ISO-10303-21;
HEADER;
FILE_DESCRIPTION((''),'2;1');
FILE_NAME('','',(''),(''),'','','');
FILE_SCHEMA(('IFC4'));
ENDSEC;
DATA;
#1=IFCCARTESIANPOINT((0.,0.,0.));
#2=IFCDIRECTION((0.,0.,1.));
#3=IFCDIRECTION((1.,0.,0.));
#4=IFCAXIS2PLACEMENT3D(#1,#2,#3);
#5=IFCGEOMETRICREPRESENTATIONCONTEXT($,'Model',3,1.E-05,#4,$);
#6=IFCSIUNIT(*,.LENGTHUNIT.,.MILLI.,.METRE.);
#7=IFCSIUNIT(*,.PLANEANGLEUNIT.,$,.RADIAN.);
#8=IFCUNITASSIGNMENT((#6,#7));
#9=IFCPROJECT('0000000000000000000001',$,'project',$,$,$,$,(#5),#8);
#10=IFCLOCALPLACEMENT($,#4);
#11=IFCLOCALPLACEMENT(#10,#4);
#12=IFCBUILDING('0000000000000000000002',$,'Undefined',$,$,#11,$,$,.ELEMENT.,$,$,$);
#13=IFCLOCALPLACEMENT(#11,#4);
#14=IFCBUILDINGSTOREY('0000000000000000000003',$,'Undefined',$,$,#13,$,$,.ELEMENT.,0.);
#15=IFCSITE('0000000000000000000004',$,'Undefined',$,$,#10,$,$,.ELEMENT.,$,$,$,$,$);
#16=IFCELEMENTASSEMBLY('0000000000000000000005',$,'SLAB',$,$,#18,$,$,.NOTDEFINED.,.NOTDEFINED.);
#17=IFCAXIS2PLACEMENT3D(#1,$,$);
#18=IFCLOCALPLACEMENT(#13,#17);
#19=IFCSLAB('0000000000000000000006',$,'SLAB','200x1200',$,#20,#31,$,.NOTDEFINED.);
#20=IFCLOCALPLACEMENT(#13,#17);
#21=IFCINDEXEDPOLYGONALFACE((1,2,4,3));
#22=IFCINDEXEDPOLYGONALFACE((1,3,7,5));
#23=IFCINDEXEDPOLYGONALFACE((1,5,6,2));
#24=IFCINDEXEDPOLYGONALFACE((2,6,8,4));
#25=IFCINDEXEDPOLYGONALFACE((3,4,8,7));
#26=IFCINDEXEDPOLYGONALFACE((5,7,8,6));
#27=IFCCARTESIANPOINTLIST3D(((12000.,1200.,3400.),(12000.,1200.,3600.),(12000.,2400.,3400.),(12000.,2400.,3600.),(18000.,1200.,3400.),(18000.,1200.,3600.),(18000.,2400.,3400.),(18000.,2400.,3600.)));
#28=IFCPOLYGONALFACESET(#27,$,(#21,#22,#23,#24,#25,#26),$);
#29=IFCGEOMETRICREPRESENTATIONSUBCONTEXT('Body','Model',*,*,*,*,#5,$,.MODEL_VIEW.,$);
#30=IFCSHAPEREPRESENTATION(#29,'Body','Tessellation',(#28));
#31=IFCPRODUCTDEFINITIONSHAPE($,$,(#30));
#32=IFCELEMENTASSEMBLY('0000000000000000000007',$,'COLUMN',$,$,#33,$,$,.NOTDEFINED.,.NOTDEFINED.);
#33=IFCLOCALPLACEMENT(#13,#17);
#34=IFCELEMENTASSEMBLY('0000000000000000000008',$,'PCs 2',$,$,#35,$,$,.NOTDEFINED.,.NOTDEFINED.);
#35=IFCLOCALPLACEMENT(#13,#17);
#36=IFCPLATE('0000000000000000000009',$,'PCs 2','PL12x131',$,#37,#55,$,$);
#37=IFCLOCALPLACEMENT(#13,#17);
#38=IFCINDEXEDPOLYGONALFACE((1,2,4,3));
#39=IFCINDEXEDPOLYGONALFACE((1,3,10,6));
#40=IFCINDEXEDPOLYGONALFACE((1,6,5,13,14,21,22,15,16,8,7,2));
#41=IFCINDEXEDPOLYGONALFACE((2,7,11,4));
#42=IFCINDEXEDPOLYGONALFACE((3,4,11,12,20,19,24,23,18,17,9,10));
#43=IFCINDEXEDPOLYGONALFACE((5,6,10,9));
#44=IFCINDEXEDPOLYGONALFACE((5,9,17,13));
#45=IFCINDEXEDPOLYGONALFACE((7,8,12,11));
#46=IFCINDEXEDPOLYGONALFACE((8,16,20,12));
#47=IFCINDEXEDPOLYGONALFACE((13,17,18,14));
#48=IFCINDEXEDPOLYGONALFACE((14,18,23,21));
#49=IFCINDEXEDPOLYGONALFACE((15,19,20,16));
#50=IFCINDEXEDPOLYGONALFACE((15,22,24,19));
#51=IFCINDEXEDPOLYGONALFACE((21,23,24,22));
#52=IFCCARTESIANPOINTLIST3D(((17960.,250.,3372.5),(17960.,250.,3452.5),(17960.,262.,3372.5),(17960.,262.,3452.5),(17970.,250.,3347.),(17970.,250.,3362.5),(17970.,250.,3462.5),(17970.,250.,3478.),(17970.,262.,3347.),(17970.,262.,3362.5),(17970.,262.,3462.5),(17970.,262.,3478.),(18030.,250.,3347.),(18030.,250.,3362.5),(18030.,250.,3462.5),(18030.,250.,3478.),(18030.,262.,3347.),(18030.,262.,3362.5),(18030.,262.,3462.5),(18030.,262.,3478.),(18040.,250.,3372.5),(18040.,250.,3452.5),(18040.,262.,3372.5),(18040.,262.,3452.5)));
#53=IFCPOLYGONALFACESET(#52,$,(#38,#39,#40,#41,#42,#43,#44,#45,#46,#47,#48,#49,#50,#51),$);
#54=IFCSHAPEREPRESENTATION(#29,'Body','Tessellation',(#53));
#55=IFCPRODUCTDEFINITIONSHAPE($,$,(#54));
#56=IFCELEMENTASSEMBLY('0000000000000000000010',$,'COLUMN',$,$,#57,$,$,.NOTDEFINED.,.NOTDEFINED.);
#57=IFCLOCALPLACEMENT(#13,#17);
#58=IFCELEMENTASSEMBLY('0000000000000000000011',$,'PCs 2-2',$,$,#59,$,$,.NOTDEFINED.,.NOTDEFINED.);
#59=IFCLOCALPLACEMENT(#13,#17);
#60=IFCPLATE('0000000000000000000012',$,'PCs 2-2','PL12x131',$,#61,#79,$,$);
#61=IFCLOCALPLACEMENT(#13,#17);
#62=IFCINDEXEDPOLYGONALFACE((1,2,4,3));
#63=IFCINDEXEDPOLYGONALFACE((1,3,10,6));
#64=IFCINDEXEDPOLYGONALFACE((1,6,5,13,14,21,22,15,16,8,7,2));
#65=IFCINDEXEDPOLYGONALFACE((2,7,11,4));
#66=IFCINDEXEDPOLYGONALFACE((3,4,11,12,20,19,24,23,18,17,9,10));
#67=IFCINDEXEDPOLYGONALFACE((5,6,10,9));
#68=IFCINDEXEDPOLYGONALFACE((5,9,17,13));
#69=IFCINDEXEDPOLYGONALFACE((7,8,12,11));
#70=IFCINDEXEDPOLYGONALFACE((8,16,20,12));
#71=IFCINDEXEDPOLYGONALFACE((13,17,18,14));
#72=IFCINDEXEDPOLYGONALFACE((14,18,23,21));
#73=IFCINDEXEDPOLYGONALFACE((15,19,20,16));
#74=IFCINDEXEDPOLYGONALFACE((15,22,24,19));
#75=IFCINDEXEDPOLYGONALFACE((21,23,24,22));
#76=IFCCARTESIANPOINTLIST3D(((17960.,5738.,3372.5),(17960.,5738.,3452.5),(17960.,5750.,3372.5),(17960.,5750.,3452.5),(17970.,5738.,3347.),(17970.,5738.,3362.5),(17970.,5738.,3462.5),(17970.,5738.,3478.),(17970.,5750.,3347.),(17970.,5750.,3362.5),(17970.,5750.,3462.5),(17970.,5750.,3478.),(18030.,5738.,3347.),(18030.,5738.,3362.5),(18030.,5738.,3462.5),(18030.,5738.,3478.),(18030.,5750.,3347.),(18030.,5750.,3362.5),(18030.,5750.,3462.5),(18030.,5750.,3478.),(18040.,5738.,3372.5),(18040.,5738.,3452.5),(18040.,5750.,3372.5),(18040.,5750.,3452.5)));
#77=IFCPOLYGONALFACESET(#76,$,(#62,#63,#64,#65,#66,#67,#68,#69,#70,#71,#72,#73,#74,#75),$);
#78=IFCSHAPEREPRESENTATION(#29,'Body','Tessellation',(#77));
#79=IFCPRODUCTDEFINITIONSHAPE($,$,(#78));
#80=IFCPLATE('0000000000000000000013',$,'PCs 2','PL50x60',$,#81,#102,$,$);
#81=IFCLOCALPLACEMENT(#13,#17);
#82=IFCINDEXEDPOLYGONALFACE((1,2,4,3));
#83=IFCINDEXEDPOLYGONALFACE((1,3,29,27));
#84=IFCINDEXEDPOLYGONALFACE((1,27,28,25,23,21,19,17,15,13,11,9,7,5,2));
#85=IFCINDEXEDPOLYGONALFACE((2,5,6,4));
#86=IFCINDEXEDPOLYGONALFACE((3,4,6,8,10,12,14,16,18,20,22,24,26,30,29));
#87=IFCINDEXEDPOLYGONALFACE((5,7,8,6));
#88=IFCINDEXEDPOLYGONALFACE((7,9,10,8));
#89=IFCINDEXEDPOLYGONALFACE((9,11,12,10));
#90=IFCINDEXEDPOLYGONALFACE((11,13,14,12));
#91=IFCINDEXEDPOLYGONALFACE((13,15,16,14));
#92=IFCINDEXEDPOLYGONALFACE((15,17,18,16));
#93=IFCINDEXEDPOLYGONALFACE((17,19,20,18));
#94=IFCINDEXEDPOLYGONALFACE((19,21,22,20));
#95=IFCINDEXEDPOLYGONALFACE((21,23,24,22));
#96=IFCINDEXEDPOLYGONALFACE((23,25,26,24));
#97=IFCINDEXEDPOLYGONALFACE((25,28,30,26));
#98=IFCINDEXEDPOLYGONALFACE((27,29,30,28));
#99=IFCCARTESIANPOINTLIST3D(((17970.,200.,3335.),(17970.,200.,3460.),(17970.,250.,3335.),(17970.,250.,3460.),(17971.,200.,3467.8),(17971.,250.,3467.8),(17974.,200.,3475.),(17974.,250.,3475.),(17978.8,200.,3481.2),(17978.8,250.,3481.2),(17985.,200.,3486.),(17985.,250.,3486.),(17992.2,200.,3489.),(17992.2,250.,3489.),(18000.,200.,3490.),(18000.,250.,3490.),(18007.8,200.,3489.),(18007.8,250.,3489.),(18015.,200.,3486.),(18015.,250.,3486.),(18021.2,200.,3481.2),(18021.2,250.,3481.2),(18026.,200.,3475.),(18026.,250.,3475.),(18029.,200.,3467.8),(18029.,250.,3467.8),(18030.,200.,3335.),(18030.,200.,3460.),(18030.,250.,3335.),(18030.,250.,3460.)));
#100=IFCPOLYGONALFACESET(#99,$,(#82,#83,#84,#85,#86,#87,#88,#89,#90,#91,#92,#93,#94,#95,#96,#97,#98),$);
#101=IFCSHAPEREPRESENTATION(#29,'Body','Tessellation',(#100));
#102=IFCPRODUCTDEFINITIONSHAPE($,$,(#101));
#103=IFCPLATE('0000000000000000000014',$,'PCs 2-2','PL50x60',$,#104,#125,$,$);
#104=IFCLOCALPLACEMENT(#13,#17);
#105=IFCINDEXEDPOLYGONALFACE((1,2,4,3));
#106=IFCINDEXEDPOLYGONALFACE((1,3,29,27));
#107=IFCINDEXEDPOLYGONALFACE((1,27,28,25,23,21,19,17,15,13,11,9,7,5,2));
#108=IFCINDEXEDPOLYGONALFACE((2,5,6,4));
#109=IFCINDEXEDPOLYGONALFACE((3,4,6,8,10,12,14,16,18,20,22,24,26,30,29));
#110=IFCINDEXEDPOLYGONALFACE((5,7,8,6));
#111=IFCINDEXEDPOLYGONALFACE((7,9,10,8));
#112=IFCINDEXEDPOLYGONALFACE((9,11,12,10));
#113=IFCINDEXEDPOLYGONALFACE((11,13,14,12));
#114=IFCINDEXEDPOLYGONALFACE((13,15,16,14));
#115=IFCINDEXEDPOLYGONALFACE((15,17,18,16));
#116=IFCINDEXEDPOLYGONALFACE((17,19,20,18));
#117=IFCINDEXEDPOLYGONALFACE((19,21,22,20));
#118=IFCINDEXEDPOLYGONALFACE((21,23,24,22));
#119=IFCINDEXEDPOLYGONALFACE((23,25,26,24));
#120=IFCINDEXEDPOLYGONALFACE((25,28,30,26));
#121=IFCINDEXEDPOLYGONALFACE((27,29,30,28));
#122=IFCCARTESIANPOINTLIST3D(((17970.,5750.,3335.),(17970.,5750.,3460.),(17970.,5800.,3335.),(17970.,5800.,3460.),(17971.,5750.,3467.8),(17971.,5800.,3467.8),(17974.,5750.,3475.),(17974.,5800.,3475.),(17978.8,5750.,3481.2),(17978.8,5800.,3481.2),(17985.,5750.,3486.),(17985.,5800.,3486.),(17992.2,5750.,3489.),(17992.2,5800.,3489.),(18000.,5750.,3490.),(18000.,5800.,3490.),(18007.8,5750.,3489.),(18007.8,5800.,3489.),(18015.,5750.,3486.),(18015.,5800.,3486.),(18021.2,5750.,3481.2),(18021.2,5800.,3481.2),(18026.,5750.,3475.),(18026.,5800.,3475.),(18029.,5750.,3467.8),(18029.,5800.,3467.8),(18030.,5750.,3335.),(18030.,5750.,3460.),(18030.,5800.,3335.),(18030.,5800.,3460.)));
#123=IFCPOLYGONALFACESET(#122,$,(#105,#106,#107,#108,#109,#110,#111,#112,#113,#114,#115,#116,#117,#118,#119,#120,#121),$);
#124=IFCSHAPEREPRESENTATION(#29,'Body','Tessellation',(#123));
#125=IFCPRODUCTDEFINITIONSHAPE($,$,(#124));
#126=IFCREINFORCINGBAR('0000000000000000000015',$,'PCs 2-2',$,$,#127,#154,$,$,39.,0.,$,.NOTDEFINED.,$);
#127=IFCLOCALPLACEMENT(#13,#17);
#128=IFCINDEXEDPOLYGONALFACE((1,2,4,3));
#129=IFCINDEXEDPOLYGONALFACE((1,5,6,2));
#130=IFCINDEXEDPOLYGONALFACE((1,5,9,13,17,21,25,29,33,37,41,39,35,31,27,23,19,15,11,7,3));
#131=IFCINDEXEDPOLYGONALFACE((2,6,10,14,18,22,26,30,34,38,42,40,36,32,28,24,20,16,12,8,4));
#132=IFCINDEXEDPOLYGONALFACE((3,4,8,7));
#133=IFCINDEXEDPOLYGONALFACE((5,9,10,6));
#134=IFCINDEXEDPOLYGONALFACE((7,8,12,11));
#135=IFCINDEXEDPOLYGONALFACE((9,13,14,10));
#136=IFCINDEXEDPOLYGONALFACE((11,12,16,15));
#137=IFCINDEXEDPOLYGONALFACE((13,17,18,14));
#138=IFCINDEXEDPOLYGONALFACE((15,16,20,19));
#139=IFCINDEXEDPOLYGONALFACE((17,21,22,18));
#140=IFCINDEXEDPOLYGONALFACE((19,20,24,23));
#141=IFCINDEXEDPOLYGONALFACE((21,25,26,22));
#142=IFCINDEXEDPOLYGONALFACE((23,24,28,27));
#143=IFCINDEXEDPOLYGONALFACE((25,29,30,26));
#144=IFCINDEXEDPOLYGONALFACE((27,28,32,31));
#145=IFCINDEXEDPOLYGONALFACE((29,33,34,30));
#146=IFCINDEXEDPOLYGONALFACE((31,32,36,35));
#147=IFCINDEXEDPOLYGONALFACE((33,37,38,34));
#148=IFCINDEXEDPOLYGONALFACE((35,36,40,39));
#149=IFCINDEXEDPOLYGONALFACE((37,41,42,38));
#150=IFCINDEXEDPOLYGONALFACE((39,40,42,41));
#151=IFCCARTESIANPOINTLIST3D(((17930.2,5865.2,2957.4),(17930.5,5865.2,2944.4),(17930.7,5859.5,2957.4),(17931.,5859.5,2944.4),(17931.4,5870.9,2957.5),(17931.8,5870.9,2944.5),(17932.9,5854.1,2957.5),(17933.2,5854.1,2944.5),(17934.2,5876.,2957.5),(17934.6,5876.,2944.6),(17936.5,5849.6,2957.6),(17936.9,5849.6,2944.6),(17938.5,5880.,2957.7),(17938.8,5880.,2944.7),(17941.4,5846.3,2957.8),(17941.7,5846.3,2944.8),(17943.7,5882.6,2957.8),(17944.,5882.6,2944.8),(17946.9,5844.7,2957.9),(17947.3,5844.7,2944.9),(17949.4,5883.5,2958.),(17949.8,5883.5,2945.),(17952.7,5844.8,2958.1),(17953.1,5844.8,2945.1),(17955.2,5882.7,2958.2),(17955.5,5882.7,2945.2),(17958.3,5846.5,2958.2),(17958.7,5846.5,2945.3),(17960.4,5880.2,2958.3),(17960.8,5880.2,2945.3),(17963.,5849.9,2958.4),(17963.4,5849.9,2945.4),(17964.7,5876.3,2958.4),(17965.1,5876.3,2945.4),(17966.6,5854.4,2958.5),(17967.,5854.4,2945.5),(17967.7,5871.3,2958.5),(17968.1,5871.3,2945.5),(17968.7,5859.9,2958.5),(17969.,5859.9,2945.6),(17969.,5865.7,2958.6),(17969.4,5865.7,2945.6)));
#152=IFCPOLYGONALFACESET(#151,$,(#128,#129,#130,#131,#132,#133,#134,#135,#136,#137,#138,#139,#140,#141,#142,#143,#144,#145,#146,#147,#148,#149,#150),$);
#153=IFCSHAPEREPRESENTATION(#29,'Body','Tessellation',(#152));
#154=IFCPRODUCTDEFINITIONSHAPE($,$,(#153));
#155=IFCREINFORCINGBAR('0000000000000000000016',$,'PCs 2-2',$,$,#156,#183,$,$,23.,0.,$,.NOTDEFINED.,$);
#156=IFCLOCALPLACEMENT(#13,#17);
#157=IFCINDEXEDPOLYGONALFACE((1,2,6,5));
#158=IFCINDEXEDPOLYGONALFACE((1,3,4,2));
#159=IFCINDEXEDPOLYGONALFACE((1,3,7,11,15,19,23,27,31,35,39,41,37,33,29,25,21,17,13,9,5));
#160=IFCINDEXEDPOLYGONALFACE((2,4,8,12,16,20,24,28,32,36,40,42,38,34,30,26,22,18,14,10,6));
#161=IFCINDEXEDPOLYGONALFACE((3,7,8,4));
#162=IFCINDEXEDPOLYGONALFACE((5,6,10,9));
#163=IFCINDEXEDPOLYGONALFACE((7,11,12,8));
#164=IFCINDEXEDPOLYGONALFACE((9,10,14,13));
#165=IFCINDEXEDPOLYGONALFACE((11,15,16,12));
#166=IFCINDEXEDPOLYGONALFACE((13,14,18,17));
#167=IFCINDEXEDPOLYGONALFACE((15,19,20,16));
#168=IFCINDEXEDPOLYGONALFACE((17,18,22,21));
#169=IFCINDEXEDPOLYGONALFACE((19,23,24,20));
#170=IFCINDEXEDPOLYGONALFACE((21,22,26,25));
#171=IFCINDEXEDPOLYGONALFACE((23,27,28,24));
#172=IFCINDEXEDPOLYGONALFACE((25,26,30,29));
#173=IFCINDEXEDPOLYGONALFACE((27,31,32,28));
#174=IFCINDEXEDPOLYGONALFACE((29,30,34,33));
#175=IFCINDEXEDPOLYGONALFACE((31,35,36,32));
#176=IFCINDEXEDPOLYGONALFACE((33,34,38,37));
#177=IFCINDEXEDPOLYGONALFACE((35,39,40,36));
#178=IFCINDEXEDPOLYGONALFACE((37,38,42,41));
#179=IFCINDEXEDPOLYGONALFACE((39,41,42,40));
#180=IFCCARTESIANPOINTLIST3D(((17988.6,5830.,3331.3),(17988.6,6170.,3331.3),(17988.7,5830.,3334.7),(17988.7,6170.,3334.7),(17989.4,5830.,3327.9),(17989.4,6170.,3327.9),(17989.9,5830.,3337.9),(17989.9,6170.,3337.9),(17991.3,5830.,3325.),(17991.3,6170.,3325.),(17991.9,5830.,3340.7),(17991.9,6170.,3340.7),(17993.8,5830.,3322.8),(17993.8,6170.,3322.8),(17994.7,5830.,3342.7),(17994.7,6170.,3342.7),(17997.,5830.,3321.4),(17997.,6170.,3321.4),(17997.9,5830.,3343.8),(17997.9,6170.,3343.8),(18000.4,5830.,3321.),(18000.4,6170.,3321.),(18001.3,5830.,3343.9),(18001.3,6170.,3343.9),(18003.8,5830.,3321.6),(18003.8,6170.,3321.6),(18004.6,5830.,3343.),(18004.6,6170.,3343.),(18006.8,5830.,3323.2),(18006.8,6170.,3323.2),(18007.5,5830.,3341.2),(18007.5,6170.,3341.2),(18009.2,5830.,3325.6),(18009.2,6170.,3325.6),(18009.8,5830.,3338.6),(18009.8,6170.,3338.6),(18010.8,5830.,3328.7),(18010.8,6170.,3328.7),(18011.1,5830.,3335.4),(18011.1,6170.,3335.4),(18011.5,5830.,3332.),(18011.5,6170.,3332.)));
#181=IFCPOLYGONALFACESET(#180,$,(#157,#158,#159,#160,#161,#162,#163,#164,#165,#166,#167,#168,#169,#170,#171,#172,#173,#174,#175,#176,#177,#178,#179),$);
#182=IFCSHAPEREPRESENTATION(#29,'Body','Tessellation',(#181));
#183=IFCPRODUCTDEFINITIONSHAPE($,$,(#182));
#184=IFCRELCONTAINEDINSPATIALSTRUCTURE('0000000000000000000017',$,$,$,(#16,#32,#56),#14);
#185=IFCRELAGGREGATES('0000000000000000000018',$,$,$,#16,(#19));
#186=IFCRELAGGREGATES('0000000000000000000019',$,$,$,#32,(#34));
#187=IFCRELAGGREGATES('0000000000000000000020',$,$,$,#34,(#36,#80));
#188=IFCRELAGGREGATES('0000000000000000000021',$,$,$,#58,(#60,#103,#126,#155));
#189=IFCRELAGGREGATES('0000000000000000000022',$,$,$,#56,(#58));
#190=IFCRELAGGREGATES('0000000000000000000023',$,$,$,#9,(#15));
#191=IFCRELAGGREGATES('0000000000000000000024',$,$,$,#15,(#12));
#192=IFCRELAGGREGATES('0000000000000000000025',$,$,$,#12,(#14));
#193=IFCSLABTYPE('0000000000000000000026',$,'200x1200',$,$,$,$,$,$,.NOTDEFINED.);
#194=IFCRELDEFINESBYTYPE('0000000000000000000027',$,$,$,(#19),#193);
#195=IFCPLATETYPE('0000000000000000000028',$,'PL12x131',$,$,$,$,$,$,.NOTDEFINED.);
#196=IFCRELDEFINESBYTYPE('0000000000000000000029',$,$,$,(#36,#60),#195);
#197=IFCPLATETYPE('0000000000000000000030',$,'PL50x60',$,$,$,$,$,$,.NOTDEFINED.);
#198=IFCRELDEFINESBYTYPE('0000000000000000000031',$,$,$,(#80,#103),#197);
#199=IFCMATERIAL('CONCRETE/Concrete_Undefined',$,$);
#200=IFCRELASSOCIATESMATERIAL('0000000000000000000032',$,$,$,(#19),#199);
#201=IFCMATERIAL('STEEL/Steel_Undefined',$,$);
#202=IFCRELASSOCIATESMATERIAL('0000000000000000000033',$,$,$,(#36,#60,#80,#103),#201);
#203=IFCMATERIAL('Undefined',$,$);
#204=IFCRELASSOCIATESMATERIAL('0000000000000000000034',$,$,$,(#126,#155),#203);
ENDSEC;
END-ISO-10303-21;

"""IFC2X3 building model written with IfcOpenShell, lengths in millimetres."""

from ifc_helpers import new_model, entity, si_unit, frame, frame_2d, origin_with_axes, place, context, subcontext, project, spatial, polyline, circle_curve, parameter, trimmed, segment, composite_curve, outline, extrude, source, transform, mapped, material, type_object, element, aggregate, save


model = new_model("IFC2X3")

# Units and contexts
model_context = context("Model", 3, precision=1e-05, world=origin_with_axes())
body_context = subcontext(model_context, "Body", "Model", "MODEL_VIEW")
ifc_project = project(units=[si_unit("LENGTHUNIT", "METRE", prefix="MILLI"), si_unit("PLANEANGLEUNIT", "RADIAN")], contexts=[model_context])

# Site, building, storey
site_placement = place(None, origin_with_axes())
site = spatial("IfcSite", under=ifc_project, at=site_placement, Name="Undefined", CompositionType="ELEMENT")
building_placement = place(site_placement, origin_with_axes())
building = spatial("IfcBuilding", under=site, at=building_placement, Name="Undefined", CompositionType="ELEMENT")
storey_placement = place(building_placement, origin_with_axes())
storey = spatial("IfcBuildingStorey", under=building, at=storey_placement, Name="Undefined", CompositionType="ELEMENT", Elevation=0.0)

# Shared definitions
ifc_material_1 = material(Name="STEEL/Steel_Undefined")

# Element assembly, slab
ifc_material_2 = material(Name="CONCRETE/Concrete_Undefined")
slab_type = type_object("IfcSlabType", Name="200x1200", PredefinedType="NOTDEFINED")
assembly_1_placement = place(storey_placement, origin_with_axes())
assembly_1 = element("IfcElementAssembly", 1, at=assembly_1_placement, inside=storey, Name="SLAB", AssemblyPlace="NOTDEFINED", PredefinedType="NOTDEFINED")
slab_1_placement = place(assembly_1_placement, frame((18000.0, 1200.0, 3500.0), z_axis=(0.0, 0.0, 1.0), x_axis=(0.0, 1.0, 0.0)))
slab_1 = element("IfcSlab", 2, at=slab_1_placement, type_object=slab_type, material=ifc_material_2, Name="SLAB", Description="200x1200", PredefinedType="NOTDEFINED", context=body_context, shape_type="SweptSolid", body=[
    extrude(outline(polyline([(0.0, 0.0), (1200.0, 0.0), (1200.0, 6000.0), (0.0, 6000.0), (0.0, 0.0)])), frame((0.0, 0.0, -100.0), z_axis=(0.0, 0.0, 1.0), x_axis=(1.0, 0.0, 0.0)), (0.0, 0.0, 1.0), 200.0),
])
aggregate(assembly_1, [slab_1])

# Element assemblies, plates
assembly_2_placement = place(storey_placement, origin_with_axes())
assembly_2 = element("IfcElementAssembly", 3, at=assembly_2_placement, inside=storey, Name="COLUMN", AssemblyPlace="NOTDEFINED", PredefinedType="NOTDEFINED")
assembly_3_placement = place(assembly_2_placement, origin_with_axes())
assembly_3 = element("IfcElementAssembly", 4, at=assembly_3_placement, Name="PCs 2", AssemblyPlace="NOTDEFINED", PredefinedType="NOTDEFINED")
aggregate(assembly_2, [assembly_3])
plate_type_1 = type_object("IfcPlateType", Name="PL12x131", PredefinedType="NOTDEFINED")
plate_1_placement = place(assembly_3_placement, frame((18030.0, 256.0, 3478.0), z_axis=(0.0, 1.0, 0.0), x_axis=(0.0, 0.0, -1.0)))
plate_1 = element("IfcPlate", 5, at=plate_1_placement, type_object=plate_type_1, material=ifc_material_1, Name="PCs 2", Description="PL12x131", context=body_context, shape_type="SweptSolid", body=[
    extrude(outline(polyline([(0.0, 0.0), (15.5, 0.0), (25.5, -10.0), (105.5, -10.0), (115.5, 0.0), (131.0, 0.0), (131.0, 60.0), (115.5, 60.0), (105.5, 70.0), (25.5, 70.0), (15.5, 60.0), (0.0, 60.0), (0.0, 0.0)])), frame((0.0, 0.0, -6.0), z_axis=(0.0, 0.0, 1.0), x_axis=(1.0, 0.0, 0.0)), (0.0, 0.0, 1.0), 12.0),
])
assembly_4_placement = place(storey_placement, origin_with_axes())
assembly_4 = element("IfcElementAssembly", 6, at=assembly_4_placement, inside=storey, Name="COLUMN", AssemblyPlace="NOTDEFINED", PredefinedType="NOTDEFINED")
assembly_5_placement = place(assembly_4_placement, origin_with_axes())
assembly_5 = element("IfcElementAssembly", 7, at=assembly_5_placement, Name="PCs 2-2", AssemblyPlace="NOTDEFINED", PredefinedType="NOTDEFINED")
plate_2_placement = place(assembly_5_placement, frame((17970.0, 5744.0, 3478.0), z_axis=(0.0, -1.0, 0.0), x_axis=(0.0, 0.0, -1.0)))
plate_2 = element("IfcPlate", 8, at=plate_2_placement, type_object=plate_type_1, material=ifc_material_1, Name="PCs 2-2", Description="PL12x131", context=body_context, shape_type="SweptSolid", body=[
    extrude(outline(polyline([(0.0, 0.0), (15.5, 0.0), (25.5, -10.0), (105.5, -10.0), (115.5, 0.0), (131.0, 0.0), (131.0, 60.0), (115.5, 60.0), (105.5, 70.0), (25.5, 70.0), (15.5, 60.0), (0.0, 60.0), (0.0, 0.0)])), frame((0.0, 0.0, -6.0), z_axis=(0.0, 0.0, 1.0), x_axis=(1.0, 0.0, 0.0)), (0.0, 0.0, 1.0), 12.0),
])

# Plates
plate_type_2 = type_object("IfcPlateType", Name="PL50x60", PredefinedType="NOTDEFINED")
plate_3_placement = place(assembly_3_placement, frame((18030.0, 225.0, 3490.0), z_axis=(0.0, 1.0, 0.0), x_axis=(0.0, 0.0, -1.0)))
plate_3 = element("IfcPlate", 9, at=plate_3_placement, type_object=plate_type_2, material=ifc_material_1, Name="PCs 2", Description="PL50x60", context=body_context, shape_type="SweptSolid", body=[
    extrude(outline(composite_curve([segment(trimmed(circle_curve(frame_2d((30.0, 30.0), x_axis=(-1.0, 0.0)), 30.0), [parameter(0.0)], [parameter(1.570796)], True, "PARAMETER"), True, "CONTINUOUS"), segment(polyline([(30.0, 0.0), (155.0, 0.0), (155.0, 60.0), (30.0, 60.0)]), True, "CONTINUOUS"), segment(trimmed(circle_curve(frame_2d((30.0, 30.0), x_axis=(0.0, 1.0)), 30.0), [parameter(0.0)], [parameter(1.570796)], True, "PARAMETER"), True, "CONTINUOUS"), segment(polyline([(0.0, 30.0), (0.0, 30.0)]), True, "CONTINUOUS")], self_intersect=True)), frame((0.0, 0.0, -25.0), z_axis=(0.0, 0.0, 1.0), x_axis=(1.0, 0.0, 0.0)), (0.0, 0.0, 1.0), 50.0),
])
aggregate(assembly_3, [plate_1, plate_3])
plate_4_placement = place(assembly_5_placement, frame((17970.0, 5775.0, 3490.0), z_axis=(0.0, -1.0, 0.0), x_axis=(0.0, 0.0, -1.0)))
plate_4 = element("IfcPlate", 10, at=plate_4_placement, type_object=plate_type_2, material=ifc_material_1, Name="PCs 2-2", Description="PL50x60", context=body_context, shape_type="SweptSolid", body=[
    extrude(outline(composite_curve([segment(trimmed(circle_curve(frame_2d((30.0, 30.0), x_axis=(-1.0, 0.0)), 30.0), [parameter(0.0)], [parameter(1.570796)], True, "PARAMETER"), True, "CONTINUOUS"), segment(polyline([(30.0, 0.0), (155.0, 0.0), (155.0, 60.0), (30.0, 60.0)]), True, "CONTINUOUS"), segment(trimmed(circle_curve(frame_2d((30.0, 30.0), x_axis=(0.0, 1.0)), 30.0), [parameter(0.0)], [parameter(1.570796)], True, "PARAMETER"), True, "CONTINUOUS"), segment(polyline([(0.0, 30.0), (0.0, 30.0)]), True, "CONTINUOUS")], self_intersect=True)), frame((0.0, 0.0, -25.0), z_axis=(0.0, 0.0, 1.0), x_axis=(1.0, 0.0, 0.0)), (0.0, 0.0, 1.0), 50.0),
])

# Reinforcing bars
ifc_material_3 = material(Name="Undefined")
shared_shape_1 = source(origin_with_axes(), body_context, "Body", "AdvancedSweptSolid", [
    entity("IfcSweptDiskSolid", entity("IfcTrimmedCurve", entity("IfcLine", entity("IfcCartesianPoint", [0.0, 0.0, 0.0]), entity("IfcVector", entity("IfcDirection", [1.0, 0.0, 0.0]), 1.0)), [entity("IfcParameterValue", 0.0)], [entity("IfcParameterValue", 13.0)], True, "PARAMETER"), 19.5, None, 0.0, 13.0),
])
reinforcing_bar_1_placement = place(assembly_5_placement, frame((17949.6, 5864.0, 2958.0), z_axis=(-0.305189, 0.95225, -0.008888), x_axis=(0.02911, 0.0, -0.999576)))
reinforcing_bar_1 = element("IfcReinforcingBar", 11, at=reinforcing_bar_1_placement, material=ifc_material_3, Name="PCs 2-2", BarRole="NOTDEFINED", CrossSectionArea=0.0, NominalDiameter=39.0, context=body_context, shape_type="MappedRepresentation", body=[
    mapped(shared_shape_1, transform((0.0, 0.0, 0.0))),
])
shared_shape_2 = source(origin_with_axes(), body_context, "Body", "AdvancedSweptSolid", [
    entity("IfcSweptDiskSolid", entity("IfcTrimmedCurve", entity("IfcLine", entity("IfcCartesianPoint", [0.0, 0.0, 0.0]), entity("IfcVector", entity("IfcDirection", [1.0, 0.0, 0.0]), 1.0)), [entity("IfcParameterValue", 0.0)], [entity("IfcParameterValue", 340.0)], True, "PARAMETER"), 11.5, None, 0.0, 340.0),
])
reinforcing_bar_2_placement = place(assembly_5_placement, frame((18000.0, 5830.0, 3332.5), z_axis=(-0.182177, 0.0, 0.983266), x_axis=(0.0, 1.0, 0.0)))
reinforcing_bar_2 = element("IfcReinforcingBar", 12, at=reinforcing_bar_2_placement, material=ifc_material_3, Name="PCs 2-2", BarRole="NOTDEFINED", CrossSectionArea=0.0, NominalDiameter=23.0, context=body_context, shape_type="MappedRepresentation", body=[
    mapped(shared_shape_2, transform((0.0, 0.0, 0.0))),
])
aggregate(assembly_5, [plate_2, plate_4, reinforcing_bar_1, reinforcing_bar_2])

aggregate(assembly_4, [assembly_5])

save(model, "model.ifc")
